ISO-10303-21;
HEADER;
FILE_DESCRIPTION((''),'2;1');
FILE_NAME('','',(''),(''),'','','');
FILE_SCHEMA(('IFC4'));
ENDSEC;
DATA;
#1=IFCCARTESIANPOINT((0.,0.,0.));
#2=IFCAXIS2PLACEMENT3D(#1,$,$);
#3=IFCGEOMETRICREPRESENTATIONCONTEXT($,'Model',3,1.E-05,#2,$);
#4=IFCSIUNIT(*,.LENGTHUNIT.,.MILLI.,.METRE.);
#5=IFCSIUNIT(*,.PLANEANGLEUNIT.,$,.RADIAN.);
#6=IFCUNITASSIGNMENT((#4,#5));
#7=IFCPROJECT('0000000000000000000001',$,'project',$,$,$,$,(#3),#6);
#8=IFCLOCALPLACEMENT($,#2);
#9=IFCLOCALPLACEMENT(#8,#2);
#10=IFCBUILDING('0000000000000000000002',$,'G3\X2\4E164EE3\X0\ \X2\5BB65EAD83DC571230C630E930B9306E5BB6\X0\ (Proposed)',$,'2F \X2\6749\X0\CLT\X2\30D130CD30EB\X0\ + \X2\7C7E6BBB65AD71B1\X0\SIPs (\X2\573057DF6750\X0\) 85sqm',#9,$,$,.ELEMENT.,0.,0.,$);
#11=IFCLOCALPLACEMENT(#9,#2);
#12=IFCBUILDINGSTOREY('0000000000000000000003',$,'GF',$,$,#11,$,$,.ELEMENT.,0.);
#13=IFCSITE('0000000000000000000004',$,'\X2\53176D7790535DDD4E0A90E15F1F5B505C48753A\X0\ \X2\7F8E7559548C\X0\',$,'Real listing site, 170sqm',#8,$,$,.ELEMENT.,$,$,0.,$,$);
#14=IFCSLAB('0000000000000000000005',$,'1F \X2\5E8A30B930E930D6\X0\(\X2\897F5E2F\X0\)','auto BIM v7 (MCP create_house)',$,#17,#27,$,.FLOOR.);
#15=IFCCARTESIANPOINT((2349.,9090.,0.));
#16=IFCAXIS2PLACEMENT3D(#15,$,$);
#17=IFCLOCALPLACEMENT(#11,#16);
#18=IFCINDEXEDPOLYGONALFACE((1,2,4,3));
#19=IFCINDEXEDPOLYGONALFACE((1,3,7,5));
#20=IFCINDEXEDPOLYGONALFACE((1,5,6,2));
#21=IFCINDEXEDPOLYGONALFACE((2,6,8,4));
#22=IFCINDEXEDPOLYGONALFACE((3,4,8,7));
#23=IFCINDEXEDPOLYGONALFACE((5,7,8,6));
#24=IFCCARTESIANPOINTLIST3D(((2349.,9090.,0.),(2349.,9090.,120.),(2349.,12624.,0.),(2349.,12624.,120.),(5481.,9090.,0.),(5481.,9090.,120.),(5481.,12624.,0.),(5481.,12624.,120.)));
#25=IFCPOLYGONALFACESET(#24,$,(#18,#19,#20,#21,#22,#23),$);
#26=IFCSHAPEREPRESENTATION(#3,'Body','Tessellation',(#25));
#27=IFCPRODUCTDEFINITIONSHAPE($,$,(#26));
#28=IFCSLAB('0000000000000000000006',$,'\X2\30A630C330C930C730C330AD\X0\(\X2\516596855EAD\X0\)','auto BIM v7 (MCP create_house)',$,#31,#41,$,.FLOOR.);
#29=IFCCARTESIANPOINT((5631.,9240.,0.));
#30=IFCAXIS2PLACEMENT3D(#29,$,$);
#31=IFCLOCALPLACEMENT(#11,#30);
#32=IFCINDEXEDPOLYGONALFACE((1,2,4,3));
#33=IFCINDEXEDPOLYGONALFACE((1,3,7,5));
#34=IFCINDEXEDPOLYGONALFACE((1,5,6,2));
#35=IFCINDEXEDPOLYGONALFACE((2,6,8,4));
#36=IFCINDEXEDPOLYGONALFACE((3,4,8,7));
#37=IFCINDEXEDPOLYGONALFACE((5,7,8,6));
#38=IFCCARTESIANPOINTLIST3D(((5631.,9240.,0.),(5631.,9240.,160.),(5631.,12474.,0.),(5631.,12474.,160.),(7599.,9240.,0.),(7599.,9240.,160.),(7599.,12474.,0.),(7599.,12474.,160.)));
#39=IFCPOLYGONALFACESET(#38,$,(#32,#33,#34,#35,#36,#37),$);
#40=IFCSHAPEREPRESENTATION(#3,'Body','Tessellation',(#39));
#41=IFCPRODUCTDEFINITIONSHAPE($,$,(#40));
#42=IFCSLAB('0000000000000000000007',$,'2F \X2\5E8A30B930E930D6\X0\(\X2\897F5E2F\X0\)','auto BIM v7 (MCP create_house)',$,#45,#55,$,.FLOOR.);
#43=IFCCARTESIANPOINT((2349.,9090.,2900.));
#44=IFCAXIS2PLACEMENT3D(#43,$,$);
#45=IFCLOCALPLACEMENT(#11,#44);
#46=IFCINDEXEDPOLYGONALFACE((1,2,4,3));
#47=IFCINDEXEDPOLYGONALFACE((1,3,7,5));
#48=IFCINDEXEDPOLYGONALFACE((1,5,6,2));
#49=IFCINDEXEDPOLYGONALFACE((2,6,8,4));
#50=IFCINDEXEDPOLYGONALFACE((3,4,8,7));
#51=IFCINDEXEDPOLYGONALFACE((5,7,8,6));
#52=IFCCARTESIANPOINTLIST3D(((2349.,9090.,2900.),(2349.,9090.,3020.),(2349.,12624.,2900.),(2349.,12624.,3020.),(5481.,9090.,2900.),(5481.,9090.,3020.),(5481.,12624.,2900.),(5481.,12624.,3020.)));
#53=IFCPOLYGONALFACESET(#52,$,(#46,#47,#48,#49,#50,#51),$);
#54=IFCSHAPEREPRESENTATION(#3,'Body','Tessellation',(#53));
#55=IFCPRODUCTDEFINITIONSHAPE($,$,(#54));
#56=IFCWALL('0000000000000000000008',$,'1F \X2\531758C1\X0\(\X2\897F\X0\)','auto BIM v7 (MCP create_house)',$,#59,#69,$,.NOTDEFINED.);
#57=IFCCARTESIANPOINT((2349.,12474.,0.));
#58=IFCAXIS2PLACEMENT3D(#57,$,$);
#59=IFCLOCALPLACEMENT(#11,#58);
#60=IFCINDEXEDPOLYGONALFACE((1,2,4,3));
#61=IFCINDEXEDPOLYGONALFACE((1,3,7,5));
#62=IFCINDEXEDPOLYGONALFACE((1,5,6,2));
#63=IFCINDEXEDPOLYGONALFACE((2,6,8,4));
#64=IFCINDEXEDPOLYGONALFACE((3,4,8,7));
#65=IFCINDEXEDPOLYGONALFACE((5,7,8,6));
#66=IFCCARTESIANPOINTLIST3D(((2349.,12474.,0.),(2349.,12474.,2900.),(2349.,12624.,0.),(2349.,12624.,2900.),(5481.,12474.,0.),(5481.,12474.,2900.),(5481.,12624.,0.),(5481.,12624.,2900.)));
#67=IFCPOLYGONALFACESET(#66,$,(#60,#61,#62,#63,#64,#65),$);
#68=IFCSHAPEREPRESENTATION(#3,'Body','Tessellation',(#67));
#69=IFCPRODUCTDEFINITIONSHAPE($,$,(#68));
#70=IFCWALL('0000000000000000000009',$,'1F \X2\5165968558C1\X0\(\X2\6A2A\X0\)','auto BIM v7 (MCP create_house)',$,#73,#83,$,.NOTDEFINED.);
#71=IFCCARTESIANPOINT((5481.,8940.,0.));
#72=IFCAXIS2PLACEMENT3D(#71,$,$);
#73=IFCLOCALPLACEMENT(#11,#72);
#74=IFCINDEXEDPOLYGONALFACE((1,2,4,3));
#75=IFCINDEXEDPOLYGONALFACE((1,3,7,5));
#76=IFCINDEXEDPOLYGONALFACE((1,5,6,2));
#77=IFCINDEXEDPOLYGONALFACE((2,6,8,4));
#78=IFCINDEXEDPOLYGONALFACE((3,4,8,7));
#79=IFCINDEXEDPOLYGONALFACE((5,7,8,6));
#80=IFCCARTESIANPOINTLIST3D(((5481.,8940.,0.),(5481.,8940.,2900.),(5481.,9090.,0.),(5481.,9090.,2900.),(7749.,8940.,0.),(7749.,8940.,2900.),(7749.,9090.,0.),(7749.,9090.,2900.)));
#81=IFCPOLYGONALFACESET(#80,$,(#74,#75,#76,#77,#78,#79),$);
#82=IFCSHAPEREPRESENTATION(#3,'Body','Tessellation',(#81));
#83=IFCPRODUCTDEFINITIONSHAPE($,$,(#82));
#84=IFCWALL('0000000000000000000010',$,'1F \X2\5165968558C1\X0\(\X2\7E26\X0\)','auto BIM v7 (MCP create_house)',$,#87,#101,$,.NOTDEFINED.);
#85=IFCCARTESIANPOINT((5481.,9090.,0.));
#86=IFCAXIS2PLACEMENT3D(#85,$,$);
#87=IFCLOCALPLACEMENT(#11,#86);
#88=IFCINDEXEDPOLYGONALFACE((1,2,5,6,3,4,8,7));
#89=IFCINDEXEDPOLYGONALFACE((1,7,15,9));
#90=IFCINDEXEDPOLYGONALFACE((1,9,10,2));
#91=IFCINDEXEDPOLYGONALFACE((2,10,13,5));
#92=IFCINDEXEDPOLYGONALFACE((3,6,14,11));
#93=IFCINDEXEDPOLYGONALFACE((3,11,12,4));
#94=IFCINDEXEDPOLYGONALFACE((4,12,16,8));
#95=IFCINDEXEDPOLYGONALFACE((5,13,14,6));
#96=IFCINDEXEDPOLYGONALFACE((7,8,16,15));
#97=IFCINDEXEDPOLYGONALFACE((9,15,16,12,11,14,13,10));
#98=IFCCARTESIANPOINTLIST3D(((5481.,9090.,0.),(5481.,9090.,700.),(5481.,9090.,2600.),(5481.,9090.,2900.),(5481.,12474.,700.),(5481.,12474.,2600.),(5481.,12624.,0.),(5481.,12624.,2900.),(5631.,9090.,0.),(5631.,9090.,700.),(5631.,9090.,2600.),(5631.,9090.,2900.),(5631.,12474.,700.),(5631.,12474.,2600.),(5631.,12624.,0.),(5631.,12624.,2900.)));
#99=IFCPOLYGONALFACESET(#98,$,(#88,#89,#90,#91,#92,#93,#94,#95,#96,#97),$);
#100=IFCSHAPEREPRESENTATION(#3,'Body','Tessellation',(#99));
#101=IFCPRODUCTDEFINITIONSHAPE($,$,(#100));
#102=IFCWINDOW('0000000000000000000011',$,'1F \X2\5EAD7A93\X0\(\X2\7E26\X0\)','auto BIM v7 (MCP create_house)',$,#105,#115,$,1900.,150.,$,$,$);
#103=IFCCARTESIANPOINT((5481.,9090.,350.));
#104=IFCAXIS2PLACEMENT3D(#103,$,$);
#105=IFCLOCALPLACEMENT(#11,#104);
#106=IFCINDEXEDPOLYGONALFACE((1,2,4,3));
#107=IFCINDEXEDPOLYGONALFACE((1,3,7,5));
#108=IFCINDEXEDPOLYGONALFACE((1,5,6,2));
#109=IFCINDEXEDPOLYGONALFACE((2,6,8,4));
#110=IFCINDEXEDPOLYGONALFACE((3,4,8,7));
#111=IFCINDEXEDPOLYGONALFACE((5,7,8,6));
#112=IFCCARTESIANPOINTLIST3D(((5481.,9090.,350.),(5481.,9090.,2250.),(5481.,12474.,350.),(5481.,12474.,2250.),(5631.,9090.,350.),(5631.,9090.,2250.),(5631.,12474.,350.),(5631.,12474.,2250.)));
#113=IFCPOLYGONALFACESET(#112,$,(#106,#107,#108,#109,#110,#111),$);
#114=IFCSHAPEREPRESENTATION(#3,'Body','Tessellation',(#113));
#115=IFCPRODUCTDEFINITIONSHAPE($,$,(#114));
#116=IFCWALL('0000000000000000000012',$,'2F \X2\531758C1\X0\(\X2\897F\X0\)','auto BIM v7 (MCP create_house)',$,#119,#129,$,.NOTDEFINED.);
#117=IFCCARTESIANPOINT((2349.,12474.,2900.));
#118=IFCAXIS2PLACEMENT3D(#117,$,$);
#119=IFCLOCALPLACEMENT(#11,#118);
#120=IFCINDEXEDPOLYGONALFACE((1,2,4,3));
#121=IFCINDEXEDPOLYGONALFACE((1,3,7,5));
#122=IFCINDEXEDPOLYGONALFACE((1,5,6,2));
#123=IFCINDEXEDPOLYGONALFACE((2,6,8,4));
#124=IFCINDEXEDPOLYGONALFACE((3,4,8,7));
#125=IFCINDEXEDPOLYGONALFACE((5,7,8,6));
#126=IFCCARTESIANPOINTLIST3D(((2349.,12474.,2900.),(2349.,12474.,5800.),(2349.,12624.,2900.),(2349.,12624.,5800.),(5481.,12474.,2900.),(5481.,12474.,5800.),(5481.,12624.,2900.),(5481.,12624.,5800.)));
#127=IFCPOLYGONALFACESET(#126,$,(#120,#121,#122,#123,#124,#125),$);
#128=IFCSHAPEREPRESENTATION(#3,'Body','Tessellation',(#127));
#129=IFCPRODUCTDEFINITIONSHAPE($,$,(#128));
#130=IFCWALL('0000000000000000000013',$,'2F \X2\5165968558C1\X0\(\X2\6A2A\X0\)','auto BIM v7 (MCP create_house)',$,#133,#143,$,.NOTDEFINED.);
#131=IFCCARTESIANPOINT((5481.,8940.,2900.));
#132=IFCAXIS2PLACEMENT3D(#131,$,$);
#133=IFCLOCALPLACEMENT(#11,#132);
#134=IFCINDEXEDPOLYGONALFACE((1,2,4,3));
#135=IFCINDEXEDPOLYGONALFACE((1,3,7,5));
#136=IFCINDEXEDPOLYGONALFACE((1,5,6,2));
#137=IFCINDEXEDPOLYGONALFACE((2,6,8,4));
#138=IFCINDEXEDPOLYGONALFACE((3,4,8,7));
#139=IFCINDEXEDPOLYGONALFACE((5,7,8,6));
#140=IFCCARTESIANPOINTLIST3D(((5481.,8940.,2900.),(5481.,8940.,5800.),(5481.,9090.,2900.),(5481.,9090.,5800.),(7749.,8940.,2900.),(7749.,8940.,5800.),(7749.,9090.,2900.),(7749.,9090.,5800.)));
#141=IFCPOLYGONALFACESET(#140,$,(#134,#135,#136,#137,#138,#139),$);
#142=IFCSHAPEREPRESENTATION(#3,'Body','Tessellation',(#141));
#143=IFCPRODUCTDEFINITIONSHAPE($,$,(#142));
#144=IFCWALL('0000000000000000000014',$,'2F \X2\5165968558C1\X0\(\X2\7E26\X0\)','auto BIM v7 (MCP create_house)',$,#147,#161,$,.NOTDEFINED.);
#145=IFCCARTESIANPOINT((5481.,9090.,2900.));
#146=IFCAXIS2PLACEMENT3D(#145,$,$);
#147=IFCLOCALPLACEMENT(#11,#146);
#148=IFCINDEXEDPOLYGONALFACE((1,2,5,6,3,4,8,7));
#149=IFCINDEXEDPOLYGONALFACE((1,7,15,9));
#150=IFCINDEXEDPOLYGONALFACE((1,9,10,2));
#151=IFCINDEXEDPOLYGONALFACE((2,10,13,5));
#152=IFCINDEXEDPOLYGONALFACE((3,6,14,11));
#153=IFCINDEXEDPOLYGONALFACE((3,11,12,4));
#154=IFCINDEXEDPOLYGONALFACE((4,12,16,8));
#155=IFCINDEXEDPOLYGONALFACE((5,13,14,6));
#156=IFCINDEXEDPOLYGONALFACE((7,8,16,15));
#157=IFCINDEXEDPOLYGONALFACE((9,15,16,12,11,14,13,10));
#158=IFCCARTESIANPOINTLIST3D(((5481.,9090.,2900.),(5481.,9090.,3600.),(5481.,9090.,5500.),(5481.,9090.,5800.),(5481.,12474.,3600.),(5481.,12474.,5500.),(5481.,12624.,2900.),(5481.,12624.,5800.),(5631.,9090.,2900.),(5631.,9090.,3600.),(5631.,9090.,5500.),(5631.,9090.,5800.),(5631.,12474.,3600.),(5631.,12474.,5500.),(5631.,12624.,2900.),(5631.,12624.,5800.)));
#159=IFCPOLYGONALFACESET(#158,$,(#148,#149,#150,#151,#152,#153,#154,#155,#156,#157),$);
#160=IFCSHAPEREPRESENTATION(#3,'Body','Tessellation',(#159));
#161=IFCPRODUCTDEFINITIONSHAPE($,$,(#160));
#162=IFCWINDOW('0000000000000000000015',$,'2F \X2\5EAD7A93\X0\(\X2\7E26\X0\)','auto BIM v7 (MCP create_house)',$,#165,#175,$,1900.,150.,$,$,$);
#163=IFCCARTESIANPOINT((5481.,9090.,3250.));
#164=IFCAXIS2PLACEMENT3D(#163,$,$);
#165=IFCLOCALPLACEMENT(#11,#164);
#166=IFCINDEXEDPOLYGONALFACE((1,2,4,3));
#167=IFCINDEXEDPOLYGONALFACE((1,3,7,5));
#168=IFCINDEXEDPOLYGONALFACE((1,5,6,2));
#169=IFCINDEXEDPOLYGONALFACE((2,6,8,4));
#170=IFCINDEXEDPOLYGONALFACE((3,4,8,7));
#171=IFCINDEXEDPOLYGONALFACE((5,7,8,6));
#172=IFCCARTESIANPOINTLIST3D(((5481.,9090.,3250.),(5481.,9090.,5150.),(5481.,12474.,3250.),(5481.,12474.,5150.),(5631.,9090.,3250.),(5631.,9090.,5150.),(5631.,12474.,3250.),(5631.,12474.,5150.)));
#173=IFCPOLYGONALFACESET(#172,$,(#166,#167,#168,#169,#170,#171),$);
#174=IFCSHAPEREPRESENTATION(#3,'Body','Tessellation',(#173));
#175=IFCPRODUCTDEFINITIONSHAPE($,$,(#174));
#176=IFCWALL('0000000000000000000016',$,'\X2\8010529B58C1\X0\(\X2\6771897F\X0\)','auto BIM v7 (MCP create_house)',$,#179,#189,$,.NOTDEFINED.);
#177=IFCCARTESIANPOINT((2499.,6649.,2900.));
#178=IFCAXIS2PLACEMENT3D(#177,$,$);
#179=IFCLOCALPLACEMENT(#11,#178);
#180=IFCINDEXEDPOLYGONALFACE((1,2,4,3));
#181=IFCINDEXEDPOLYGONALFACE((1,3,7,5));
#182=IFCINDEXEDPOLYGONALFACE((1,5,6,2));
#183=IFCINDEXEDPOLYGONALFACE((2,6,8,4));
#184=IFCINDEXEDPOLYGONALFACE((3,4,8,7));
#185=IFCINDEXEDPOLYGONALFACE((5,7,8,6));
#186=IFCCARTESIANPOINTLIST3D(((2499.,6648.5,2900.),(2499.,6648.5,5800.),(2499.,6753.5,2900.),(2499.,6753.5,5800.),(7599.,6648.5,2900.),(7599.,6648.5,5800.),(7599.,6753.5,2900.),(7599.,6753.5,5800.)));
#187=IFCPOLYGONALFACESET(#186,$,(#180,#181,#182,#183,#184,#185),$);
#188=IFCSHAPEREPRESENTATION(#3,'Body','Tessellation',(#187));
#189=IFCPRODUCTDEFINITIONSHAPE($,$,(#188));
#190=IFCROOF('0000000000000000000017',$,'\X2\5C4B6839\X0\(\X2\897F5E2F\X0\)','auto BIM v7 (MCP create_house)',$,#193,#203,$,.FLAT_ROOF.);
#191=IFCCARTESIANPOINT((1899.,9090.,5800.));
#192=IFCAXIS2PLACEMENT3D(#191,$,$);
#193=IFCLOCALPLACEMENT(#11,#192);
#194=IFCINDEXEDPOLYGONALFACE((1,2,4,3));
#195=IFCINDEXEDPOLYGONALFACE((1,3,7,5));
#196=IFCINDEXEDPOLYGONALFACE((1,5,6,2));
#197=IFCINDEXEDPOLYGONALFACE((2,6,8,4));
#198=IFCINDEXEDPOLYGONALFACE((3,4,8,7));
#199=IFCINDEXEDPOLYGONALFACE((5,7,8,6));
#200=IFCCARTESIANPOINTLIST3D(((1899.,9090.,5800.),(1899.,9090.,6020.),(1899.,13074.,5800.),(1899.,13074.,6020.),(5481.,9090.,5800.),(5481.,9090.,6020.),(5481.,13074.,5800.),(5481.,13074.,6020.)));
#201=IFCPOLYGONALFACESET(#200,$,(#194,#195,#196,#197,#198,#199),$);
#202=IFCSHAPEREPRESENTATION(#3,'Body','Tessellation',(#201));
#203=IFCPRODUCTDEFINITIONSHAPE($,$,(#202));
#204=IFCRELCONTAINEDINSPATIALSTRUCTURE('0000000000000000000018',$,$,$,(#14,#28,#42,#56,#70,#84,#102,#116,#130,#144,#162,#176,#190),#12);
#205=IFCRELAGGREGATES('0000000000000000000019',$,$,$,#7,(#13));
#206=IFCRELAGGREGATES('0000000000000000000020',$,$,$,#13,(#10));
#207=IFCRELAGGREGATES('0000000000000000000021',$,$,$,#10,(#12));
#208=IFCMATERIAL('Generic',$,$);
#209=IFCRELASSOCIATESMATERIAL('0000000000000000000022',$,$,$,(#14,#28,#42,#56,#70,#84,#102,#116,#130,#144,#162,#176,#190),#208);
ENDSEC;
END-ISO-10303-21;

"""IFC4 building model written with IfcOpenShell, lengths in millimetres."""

from ifc_helpers import new_model, si_unit, frame, frame_2d, origin, place, context, project, spatial, rectangle, extrude, material, element, fill, save


model = new_model("IFC4")

# Units and contexts
model_context = context("Model", 3, precision=1e-05, world=origin())
ifc_project = project(units=[si_unit("LENGTHUNIT", "METRE", prefix="MILLI"), si_unit("PLANEANGLEUNIT", "RADIAN")], contexts=[model_context])

# Site, building, storey
site_placement = place(None, origin())
site = spatial("IfcSite", under=ifc_project, at=site_placement, Name="北海道川上郡弟子屈町 美留和", ObjectType="Real listing site, 170sqm", CompositionType="ELEMENT", RefElevation=0.0)
building_placement = place(site_placement, origin())
building = spatial("IfcBuilding", under=site, at=building_placement, Name="G3世代 家庭菜園テラスの家 (Proposed)", ObjectType="2F 杉CLTパネル + 籾殻断熱SIPs (地域材) 85sqm", CompositionType="ELEMENT", ElevationOfRefHeight=0.0, ElevationOfTerrain=0.0)
storey_placement = place(building_placement, origin())
storey = spatial("IfcBuildingStorey", under=building, at=storey_placement, Name="GF", CompositionType="ELEMENT", Elevation=0.0)

# Slabs
ifc_material = material(Name="Generic")
slab_1_placement = place(storey_placement, frame((2349.0, 9090.0, 0.0)))
element("IfcSlab", 1, at=slab_1_placement, inside=storey, material=ifc_material, Name="1F 床スラブ(西帯)", Description="auto BIM v7 (MCP create_house)", PredefinedType="FLOOR", context=model_context, shape_type="SweptSolid", body=[
    extrude(rectangle(XDim=3132.0, YDim=3534.0, at=frame_2d((1566.0, 1767.0))), frame((2349.0, 9090.0, 0.0)), (0.0, 0.0, 1.0), 120.0),
])
slab_2_placement = place(storey_placement, frame((5631.0, 9240.0, 0.0)))
element("IfcSlab", 2, at=slab_2_placement, inside=storey, material=ifc_material, Name="ウッドデッキ(入隅庭)", Description="auto BIM v7 (MCP create_house)", PredefinedType="FLOOR", context=model_context, shape_type="SweptSolid", body=[
    extrude(rectangle(XDim=1968.0, YDim=3234.0, at=frame_2d((984.0, 1617.0))), frame((5631.0, 9240.0, 0.0)), (0.0, 0.0, 1.0), 160.0),
])
slab_3_placement = place(storey_placement, frame((2349.0, 9090.0, 2900.0)))
element("IfcSlab", 3, at=slab_3_placement, inside=storey, material=ifc_material, Name="2F 床スラブ(西帯)", Description="auto BIM v7 (MCP create_house)", PredefinedType="FLOOR", context=model_context, shape_type="SweptSolid", body=[
    extrude(rectangle(XDim=3132.0, YDim=3534.0, at=frame_2d((1566.0, 1767.0))), frame((2349.0, 9090.0, 2900.0)), (0.0, 0.0, 1.0), 120.0),
])

# Walls
wall_1_placement = place(storey_placement, frame((2349.0, 12474.0, 0.0)))
element("IfcWall", 4, at=wall_1_placement, inside=storey, material=ifc_material, Name="1F 北壁(西)", Description="auto BIM v7 (MCP create_house)", PredefinedType="NOTDEFINED", context=model_context, shape_type="SweptSolid", body=[
    extrude(rectangle(XDim=3132.0, YDim=150.0, at=frame_2d((1566.0, 75.0))), frame((2349.0, 12474.0, 0.0)), (0.0, 0.0, 1.0), 2900.0),
])
wall_2_placement = place(storey_placement, frame((5481.0, 8940.0, 0.0)))
element("IfcWall", 5, at=wall_2_placement, inside=storey, material=ifc_material, Name="1F 入隅壁(横)", Description="auto BIM v7 (MCP create_house)", PredefinedType="NOTDEFINED", context=model_context, shape_type="SweptSolid", body=[
    extrude(rectangle(XDim=2268.0, YDim=150.0, at=frame_2d((1134.0, 75.0))), frame((5481.0, 8940.0, 0.0)), (0.0, 0.0, 1.0), 2900.0),
])

# Wall, opening, window
wall_3_placement = place(storey_placement, frame((5481.0, 9090.0, 0.0)))
wall_3 = element("IfcWall", 6, at=wall_3_placement, inside=storey, material=ifc_material, Name="1F 入隅壁(縦)", Description="auto BIM v7 (MCP create_house)", PredefinedType="NOTDEFINED", context=model_context, shape_type="SweptSolid", body=[
    extrude(rectangle(XDim=150.0, YDim=3534.0, at=frame_2d((75.0, 1767.0))), frame((5481.0, 9090.0, 0.0)), (0.0, 0.0, 1.0), 2900.0),
])
opening_1_placement = place(storey_placement, frame((5481.0, 9090.0, 350.0)))
opening_1 = element("IfcOpeningElement", 7, at=opening_1_placement, cuts=wall_3, PredefinedType="NOTDEFINED", context=model_context, shape_type="SweptSolid", body=[
    extrude(rectangle(XDim=150.0, YDim=3384.0, at=frame_2d((75.0, 1692.0))), frame((5481.0, 9090.0, 350.0)), (0.0, 0.0, 1.0), 1900.0),
])
window_1_placement = place(storey_placement, frame((5481.0, 9090.0, 350.0)))
window_1 = element("IfcWindow", 8, at=window_1_placement, inside=storey, material=ifc_material, Name="1F 庭窓(縦)", Description="auto BIM v7 (MCP create_house)", OverallHeight=1900.0, OverallWidth=150.0, context=model_context, shape_type="SweptSolid", body=[
    extrude(rectangle(XDim=150.0, YDim=3384.0, at=frame_2d((75.0, 1692.0))), frame((5481.0, 9090.0, 350.0)), (0.0, 0.0, 1.0), 1900.0),
])
fill(opening_1, window_1)

# Walls
wall_4_placement = place(storey_placement, frame((2349.0, 12474.0, 2900.0)))
element("IfcWall", 9, at=wall_4_placement, inside=storey, material=ifc_material, Name="2F 北壁(西)", Description="auto BIM v7 (MCP create_house)", PredefinedType="NOTDEFINED", context=model_context, shape_type="SweptSolid", body=[
    extrude(rectangle(XDim=3132.0, YDim=150.0, at=frame_2d((1566.0, 75.0))), frame((2349.0, 12474.0, 2900.0)), (0.0, 0.0, 1.0), 2900.0),
])
wall_5_placement = place(storey_placement, frame((5481.0, 8940.0, 2900.0)))
element("IfcWall", 10, at=wall_5_placement, inside=storey, material=ifc_material, Name="2F 入隅壁(横)", Description="auto BIM v7 (MCP create_house)", PredefinedType="NOTDEFINED", context=model_context, shape_type="SweptSolid", body=[
    extrude(rectangle(XDim=2268.0, YDim=150.0, at=frame_2d((1134.0, 75.0))), frame((5481.0, 8940.0, 2900.0)), (0.0, 0.0, 1.0), 2900.0),
])

# Wall, opening, window
wall_6_placement = place(storey_placement, frame((5481.0, 9090.0, 2900.0)))
wall_6 = element("IfcWall", 11, at=wall_6_placement, inside=storey, material=ifc_material, Name="2F 入隅壁(縦)", Description="auto BIM v7 (MCP create_house)", PredefinedType="NOTDEFINED", context=model_context, shape_type="SweptSolid", body=[
    extrude(rectangle(XDim=150.0, YDim=3534.0, at=frame_2d((75.0, 1767.0))), frame((5481.0, 9090.0, 2900.0)), (0.0, 0.0, 1.0), 2900.0),
])
opening_2_placement = place(storey_placement, frame((5481.0, 9090.0, 3250.0)))
opening_2 = element("IfcOpeningElement", 12, at=opening_2_placement, cuts=wall_6, PredefinedType="NOTDEFINED", context=model_context, shape_type="SweptSolid", body=[
    extrude(rectangle(XDim=150.0, YDim=3384.0, at=frame_2d((75.0, 1692.0))), frame((5481.0, 9090.0, 3250.0)), (0.0, 0.0, 1.0), 1900.0),
])
window_2_placement = place(storey_placement, frame((5481.0, 9090.0, 3250.0)))
window_2 = element("IfcWindow", 13, at=window_2_placement, inside=storey, material=ifc_material, Name="2F 庭窓(縦)", Description="auto BIM v7 (MCP create_house)", OverallHeight=1900.0, OverallWidth=150.0, context=model_context, shape_type="SweptSolid", body=[
    extrude(rectangle(XDim=150.0, YDim=3384.0, at=frame_2d((75.0, 1692.0))), frame((5481.0, 9090.0, 3250.0)), (0.0, 0.0, 1.0), 1900.0),
])
fill(opening_2, window_2)

# Wall
wall_7_placement = place(storey_placement, frame((2499.0, 6649.0, 2900.0)))
element("IfcWall", 14, at=wall_7_placement, inside=storey, material=ifc_material, Name="耐力壁(東西)", Description="auto BIM v7 (MCP create_house)", PredefinedType="NOTDEFINED", context=model_context, shape_type="SweptSolid", body=[
    extrude(rectangle(XDim=5100.0, YDim=105.0, at=frame_2d((2550.0, 52.0))), frame((2499.0, 6649.0, 2900.0)), (0.0, 0.0, 1.0), 2900.0),
])

# Roof
for number, where, name in (
    (15, (1899.0, 9090.0, 5800.0), "屋根(西帯)"),
):
    element("IfcRoof", number, at=place(storey_placement, frame(where)), inside=storey, material=ifc_material, Name=name, Description="auto BIM v7 (MCP create_house)", PredefinedType="FLAT_ROOF", context=model_context, shape_type="SweptSolid", body=[
        extrude(rectangle(XDim=3582.0, YDim=3984.0, at=frame_2d((1791.0, 1992.0))), frame((1899.0, 9090.0, 5800.0)), (0.0, 0.0, 1.0), 220.0),
    ])

save(model, "model.ifc")
